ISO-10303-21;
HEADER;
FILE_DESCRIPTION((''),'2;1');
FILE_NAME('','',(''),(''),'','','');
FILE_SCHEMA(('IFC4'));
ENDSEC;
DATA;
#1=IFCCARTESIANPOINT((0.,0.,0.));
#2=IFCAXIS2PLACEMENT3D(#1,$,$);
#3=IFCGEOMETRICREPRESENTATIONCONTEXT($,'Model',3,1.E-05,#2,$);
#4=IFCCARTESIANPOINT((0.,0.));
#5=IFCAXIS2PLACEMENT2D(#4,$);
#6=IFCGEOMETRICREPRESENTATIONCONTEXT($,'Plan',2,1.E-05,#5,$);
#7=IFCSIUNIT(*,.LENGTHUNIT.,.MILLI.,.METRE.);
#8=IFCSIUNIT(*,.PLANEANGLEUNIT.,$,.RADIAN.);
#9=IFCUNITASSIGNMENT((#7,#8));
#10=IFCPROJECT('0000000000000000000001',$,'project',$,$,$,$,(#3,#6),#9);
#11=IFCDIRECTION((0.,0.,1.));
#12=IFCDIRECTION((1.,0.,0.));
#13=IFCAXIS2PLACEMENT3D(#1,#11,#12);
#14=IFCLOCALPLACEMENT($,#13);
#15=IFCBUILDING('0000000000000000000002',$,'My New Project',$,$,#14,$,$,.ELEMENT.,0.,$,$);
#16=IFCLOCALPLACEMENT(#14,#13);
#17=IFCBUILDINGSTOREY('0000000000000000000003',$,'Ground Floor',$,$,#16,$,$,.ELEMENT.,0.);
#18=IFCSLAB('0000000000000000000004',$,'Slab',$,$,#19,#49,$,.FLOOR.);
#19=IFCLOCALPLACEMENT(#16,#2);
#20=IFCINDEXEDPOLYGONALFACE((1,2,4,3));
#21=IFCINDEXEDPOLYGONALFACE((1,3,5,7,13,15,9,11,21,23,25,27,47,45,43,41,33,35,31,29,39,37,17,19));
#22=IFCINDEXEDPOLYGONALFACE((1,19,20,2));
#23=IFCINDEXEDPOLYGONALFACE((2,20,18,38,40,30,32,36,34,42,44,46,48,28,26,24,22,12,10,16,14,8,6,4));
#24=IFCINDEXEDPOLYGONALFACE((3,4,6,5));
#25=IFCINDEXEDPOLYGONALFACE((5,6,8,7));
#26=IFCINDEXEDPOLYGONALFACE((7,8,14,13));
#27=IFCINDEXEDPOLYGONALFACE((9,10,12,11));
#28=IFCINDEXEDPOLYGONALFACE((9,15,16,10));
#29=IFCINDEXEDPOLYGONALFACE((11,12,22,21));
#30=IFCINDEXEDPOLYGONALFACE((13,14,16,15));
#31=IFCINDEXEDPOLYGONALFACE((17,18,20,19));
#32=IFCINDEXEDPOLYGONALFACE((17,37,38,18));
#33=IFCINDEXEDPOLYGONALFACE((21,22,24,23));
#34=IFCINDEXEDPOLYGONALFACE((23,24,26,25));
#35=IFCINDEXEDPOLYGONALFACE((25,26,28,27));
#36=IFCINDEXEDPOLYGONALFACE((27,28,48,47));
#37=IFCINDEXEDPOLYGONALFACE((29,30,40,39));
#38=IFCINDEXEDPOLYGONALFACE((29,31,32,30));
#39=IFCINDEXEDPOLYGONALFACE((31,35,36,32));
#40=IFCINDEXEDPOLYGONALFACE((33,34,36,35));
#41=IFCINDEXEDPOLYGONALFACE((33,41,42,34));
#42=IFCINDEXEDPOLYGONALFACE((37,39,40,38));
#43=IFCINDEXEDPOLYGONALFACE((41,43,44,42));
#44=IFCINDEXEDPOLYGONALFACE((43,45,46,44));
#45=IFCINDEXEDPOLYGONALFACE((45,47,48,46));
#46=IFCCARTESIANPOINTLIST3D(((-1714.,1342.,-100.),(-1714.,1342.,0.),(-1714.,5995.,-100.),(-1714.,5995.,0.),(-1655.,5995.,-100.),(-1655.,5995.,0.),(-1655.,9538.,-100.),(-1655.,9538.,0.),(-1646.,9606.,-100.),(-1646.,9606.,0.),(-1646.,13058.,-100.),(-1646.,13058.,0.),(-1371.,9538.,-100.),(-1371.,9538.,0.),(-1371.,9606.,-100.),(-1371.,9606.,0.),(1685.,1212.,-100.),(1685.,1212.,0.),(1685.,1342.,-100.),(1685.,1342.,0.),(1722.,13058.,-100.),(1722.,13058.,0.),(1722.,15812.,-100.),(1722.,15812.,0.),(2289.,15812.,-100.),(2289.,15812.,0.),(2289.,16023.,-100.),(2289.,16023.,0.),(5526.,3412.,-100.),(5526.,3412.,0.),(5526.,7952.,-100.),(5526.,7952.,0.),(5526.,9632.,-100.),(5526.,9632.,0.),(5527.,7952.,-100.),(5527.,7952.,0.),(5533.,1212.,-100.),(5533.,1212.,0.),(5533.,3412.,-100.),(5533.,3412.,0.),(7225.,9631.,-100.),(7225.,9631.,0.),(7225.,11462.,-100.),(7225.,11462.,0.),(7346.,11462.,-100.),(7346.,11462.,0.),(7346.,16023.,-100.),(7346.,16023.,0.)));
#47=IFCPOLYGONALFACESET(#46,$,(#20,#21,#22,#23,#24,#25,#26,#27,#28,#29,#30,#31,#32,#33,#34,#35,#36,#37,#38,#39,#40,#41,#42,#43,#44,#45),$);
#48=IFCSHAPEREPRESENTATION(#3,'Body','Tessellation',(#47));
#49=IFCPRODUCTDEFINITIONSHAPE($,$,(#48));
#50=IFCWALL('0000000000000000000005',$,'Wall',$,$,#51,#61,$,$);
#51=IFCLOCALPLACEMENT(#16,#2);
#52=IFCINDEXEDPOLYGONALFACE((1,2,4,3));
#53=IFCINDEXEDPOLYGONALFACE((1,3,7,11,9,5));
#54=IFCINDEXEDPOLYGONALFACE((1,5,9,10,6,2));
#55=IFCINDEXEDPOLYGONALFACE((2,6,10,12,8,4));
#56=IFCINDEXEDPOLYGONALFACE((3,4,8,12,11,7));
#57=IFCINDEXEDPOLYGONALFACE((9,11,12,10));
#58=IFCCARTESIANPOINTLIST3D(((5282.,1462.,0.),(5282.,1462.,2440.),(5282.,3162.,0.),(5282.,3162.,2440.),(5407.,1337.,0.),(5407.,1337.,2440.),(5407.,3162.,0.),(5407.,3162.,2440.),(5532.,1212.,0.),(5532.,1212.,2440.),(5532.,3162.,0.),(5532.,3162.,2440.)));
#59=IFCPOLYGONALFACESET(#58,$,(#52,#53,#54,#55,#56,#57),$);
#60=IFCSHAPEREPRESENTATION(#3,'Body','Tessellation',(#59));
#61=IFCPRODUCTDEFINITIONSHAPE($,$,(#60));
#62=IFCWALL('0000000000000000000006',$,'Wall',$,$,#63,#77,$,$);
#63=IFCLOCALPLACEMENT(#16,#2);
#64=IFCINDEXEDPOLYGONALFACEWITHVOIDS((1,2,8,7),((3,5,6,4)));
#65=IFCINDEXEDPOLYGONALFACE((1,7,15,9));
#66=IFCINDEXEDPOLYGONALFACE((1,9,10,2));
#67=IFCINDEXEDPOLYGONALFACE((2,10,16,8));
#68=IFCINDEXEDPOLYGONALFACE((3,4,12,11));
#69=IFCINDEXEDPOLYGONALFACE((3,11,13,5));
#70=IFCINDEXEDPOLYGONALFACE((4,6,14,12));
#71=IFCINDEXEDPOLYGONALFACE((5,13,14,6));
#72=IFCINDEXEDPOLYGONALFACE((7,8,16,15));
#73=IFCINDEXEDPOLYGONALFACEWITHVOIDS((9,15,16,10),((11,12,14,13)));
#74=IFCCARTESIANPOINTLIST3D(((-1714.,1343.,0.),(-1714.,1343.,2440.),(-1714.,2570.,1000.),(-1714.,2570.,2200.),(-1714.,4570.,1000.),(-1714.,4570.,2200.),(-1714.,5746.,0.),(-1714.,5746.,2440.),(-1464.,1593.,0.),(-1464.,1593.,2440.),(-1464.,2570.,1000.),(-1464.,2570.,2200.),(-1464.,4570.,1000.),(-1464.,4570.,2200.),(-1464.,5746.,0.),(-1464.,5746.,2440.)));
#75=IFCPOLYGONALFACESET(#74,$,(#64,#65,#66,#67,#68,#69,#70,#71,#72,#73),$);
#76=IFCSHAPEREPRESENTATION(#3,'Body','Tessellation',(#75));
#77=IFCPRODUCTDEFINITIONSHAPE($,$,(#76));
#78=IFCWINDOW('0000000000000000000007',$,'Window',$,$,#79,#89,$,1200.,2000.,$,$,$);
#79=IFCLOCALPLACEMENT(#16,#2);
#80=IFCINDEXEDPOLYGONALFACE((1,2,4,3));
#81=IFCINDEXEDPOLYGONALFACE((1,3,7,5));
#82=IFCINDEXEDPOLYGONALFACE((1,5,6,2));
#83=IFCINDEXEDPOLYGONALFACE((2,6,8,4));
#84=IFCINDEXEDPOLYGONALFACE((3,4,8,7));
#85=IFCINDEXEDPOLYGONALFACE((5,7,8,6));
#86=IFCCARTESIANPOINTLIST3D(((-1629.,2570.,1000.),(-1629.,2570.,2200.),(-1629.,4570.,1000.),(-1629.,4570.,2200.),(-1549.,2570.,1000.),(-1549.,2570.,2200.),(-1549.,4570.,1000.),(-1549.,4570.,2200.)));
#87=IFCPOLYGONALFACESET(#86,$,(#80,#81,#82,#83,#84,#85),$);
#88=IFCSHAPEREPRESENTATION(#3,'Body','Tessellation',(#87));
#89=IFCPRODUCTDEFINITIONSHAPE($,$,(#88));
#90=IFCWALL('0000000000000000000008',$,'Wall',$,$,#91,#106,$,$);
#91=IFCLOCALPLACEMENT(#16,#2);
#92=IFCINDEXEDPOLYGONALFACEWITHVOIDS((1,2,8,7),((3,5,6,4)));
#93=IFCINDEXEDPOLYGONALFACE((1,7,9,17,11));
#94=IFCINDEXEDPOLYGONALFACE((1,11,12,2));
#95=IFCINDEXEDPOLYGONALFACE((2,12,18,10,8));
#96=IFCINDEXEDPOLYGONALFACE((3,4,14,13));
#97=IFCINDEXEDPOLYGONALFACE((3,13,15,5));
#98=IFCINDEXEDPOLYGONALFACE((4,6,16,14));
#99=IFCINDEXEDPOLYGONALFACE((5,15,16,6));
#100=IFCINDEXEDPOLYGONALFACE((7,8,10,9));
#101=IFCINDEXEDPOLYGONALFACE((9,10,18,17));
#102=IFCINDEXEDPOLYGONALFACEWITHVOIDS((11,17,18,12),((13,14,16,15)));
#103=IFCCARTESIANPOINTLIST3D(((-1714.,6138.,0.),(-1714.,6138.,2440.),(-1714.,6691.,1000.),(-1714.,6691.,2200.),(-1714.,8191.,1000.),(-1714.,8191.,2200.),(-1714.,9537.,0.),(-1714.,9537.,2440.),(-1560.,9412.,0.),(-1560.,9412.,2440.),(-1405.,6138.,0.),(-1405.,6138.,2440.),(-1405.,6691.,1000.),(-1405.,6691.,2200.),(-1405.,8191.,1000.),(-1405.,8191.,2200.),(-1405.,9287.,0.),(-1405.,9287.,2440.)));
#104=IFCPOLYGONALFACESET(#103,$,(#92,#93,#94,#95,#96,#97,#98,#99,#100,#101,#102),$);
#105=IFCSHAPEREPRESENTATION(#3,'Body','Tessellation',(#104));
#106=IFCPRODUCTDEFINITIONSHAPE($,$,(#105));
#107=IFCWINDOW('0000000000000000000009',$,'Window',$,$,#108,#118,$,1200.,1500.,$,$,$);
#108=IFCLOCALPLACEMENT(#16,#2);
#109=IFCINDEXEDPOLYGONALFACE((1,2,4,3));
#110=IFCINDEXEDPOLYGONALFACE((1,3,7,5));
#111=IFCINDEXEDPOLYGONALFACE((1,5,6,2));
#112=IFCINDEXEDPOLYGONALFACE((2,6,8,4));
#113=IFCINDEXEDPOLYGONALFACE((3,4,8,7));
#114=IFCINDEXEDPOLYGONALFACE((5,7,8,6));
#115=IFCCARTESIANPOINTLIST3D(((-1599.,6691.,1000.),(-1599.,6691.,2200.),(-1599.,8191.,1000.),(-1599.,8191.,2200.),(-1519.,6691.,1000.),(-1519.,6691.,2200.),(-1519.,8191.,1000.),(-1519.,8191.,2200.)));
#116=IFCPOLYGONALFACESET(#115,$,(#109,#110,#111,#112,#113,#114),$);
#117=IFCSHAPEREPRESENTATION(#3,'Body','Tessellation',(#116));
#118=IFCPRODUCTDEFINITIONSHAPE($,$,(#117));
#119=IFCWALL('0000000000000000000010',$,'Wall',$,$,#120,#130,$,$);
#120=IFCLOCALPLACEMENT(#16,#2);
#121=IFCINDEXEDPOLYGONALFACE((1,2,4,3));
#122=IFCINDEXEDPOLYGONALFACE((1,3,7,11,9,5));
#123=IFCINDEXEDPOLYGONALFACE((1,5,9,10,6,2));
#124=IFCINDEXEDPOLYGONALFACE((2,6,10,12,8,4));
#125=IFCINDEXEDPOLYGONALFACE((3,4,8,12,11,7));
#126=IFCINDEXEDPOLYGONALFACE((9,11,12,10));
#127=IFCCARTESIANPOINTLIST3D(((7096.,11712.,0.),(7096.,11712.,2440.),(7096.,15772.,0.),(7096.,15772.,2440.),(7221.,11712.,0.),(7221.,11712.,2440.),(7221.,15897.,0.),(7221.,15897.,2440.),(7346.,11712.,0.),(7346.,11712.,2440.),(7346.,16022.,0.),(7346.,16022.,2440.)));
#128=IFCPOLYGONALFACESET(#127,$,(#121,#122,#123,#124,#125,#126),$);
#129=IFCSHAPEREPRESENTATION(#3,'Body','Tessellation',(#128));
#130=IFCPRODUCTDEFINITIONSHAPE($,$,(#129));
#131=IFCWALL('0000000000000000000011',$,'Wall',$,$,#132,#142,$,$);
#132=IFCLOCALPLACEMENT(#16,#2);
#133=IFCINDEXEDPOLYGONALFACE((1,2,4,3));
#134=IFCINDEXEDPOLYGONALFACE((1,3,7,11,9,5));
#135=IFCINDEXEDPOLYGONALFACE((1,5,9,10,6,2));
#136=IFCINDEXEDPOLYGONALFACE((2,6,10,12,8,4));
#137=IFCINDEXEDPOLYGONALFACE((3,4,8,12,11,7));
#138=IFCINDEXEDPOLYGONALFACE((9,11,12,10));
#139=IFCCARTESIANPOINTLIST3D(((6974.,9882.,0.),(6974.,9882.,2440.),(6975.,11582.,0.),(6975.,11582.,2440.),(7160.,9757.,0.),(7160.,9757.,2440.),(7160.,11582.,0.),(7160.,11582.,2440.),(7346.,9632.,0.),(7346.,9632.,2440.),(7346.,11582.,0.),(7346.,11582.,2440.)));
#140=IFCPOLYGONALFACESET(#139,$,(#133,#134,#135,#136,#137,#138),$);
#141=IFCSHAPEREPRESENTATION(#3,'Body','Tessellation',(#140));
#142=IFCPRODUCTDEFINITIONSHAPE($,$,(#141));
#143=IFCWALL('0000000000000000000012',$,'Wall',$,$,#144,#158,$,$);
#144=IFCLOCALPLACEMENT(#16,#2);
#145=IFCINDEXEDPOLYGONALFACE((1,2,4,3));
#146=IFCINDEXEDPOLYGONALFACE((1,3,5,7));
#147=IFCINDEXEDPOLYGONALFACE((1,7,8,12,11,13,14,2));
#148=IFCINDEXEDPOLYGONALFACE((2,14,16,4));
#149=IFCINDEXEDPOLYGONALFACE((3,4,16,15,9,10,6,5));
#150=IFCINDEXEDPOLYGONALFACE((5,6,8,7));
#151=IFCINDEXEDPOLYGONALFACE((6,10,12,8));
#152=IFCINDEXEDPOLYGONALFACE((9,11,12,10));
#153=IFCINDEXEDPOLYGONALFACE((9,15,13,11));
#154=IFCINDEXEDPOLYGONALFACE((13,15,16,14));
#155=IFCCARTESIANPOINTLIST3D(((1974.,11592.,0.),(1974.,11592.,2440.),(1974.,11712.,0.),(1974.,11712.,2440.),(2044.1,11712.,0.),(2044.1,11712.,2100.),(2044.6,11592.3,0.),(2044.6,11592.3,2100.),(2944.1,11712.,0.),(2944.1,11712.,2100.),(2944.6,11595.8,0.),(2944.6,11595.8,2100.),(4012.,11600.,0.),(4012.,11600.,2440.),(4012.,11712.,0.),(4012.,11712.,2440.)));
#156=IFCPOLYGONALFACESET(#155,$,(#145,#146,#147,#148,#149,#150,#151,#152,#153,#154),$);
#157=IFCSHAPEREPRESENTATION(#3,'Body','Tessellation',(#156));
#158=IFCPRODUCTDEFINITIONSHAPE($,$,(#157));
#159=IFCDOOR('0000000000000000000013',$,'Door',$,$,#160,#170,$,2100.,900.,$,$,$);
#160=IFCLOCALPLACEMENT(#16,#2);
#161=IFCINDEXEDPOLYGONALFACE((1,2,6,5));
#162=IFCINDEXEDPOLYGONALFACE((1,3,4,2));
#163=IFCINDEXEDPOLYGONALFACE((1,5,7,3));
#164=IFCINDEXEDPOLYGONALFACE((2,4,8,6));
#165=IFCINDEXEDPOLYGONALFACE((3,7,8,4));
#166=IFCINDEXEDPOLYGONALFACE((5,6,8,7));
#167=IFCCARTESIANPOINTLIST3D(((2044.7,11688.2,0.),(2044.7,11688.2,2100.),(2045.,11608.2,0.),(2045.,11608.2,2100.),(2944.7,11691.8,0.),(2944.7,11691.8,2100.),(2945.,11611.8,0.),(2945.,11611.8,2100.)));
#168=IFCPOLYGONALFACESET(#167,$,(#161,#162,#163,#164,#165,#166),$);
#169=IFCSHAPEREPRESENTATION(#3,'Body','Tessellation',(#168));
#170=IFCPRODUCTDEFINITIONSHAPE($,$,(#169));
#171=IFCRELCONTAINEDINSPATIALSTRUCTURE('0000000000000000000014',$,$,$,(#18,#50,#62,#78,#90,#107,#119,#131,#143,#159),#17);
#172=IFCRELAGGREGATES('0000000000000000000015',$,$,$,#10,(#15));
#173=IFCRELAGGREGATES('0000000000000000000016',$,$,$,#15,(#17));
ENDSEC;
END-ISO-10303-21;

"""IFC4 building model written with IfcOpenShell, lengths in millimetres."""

from ifc_helpers import new_model, si_unit, frame, origin, origin_with_axes, origin_2d, origin_2d_with_axis, place, context, project, spatial, polyline, rectangle, outline, extrude, element, fill, save


model = new_model("IFC4")

# Units and contexts
model_context = context("Model", 3, precision=1e-05, world=origin())
plan_context = context("Plan", 2, precision=1e-05, world=origin_2d())
ifc_project = project(units=[si_unit("LENGTHUNIT", "METRE", prefix="MILLI"), si_unit("PLANEANGLEUNIT", "RADIAN")], contexts=[model_context, plan_context])

# Building, storey
building_placement = place(None, origin_with_axes())
building = spatial("IfcBuilding", under=ifc_project, at=building_placement, Name="My New Project", CompositionType="ELEMENT", ElevationOfRefHeight=0.0)
storey_placement = place(building_placement, origin_with_axes())
storey = spatial("IfcBuildingStorey", under=building, at=storey_placement, Name="Ground Floor", CompositionType="ELEMENT", Elevation=0.0)

# Slab
slab_placement = place(storey_placement, origin_with_axes())
element("IfcSlab", 1, at=slab_placement, inside=storey, Name="Slab", PredefinedType="FLOOR", context=model_context, shape_type="SweptSolid", body=[
    extrude(outline(polyline([(5533.0, 3412.0, 0.0), (5526.0, 3412.0, 0.0), (5526.0, 7952.0, 0.0), (5527.0, 7952.0, 0.0), (5526.0, 9632.0, 0.0), (7225.0, 9631.0, 0.0), (7225.0, 11462.0, 0.0), (7346.0, 11462.0, 0.0), (7346.0, 16023.0, 0.0), (2289.0, 16023.0, 0.0), (2289.0, 15812.0, 0.0), (1722.0, 15812.0, 0.0), (1722.0, 13058.0, 0.0), (-1646.0, 13058.0, 0.0), (-1646.0, 9606.0, 0.0), (-1371.0, 9606.0, 0.0), (-1371.0, 9538.0, 0.0), (-1655.0, 9538.0, 0.0), (-1655.0, 5995.0, 0.0), (-1714.0, 5995.0, 0.0), (-1714.0, 1342.0, 0.0), (1685.0, 1342.0, 0.0), (1685.0, 1212.0, 0.0), (5533.0, 1212.0, 0.0), (5533.0, 3412.0, 0.0)])), origin_with_axes(), (0.0, 0.0, -1.0), 100.0),
])

# Wall
wall_1_placement = place(storey_placement, origin_with_axes())
element("IfcWall", 2, at=wall_1_placement, inside=storey, Name="Wall", context=model_context, shape_type="SweptSolid", body=[
    extrude(outline(polyline([(5407.0, 1337.0, 0.0), (5282.0, 1462.0, 0.0), (5282.0, 3162.0, 0.0), (5407.0, 3162.0, 0.0), (5532.0, 3162.0, 0.0), (5532.0, 1212.0, 0.0), (5407.0, 1337.0, 0.0)])), origin_with_axes(), (0.0, 0.0, 1.0), 2440.0),
])

# Walls, openings, windows
wall_2_placement = place(storey_placement, origin_with_axes())
wall_2 = element("IfcWall", 3, at=wall_2_placement, inside=storey, Name="Wall", context=model_context, shape_type="SweptSolid", body=[
    extrude(outline(polyline([(-1589.0, 5746.0, 0.0), (-1464.0, 5746.0, 0.0), (-1464.0, 1593.0, 0.0), (-1589.0, 1468.0, 0.0), (-1714.0, 1343.0, 0.0), (-1714.0, 5746.0, 0.0), (-1589.0, 5746.0, 0.0)])), origin_with_axes(), (0.0, 0.0, 1.0), 2440.0),
])
opening_1_placement = place(wall_2_placement, frame((-1364.0, 3570.0, 1600.0), z_axis=(0.0, 0.0, 1.0), x_axis=(1.0, 0.0, 0.0)))
opening_1 = element("IfcOpeningElement", 4, at=opening_1_placement, cuts=wall_2, PredefinedType="OPENING", context=model_context, shape_type="SweptSolid", body=[
    extrude(rectangle(XDim=2000.0, YDim=1200.0, at=origin_2d_with_axis()), frame((0.0, 0.0, 0.0), z_axis=(-4153.0, 0.0, 0.0), x_axis=(0.0, -4153.0, 0.0)), (0.0, 0.0, 1.0), 450.0),
])
window_1_placement = place(opening_1_placement, frame((-185.0, 0.0, 0.0), z_axis=(0.0, 0.0, 1.0), x_axis=(1.0, 0.0, 0.0)))
window_1 = element("IfcWindow", 5, at=window_1_placement, inside=storey, Name="Window", OverallHeight=1200.0, OverallWidth=2000.0, context=model_context, shape_type="SweptSolid", body=[
    extrude(outline(polyline([(1000.0, 600.0, 0.0), (1000.0, -600.0, 0.0), (-1000.0, -600.0, 0.0), (-1000.0, 600.0, 0.0), (1000.0, 600.0, 0.0)])), frame((0.0, 0.0, 0.0), z_axis=(-4153.0, 0.0, 0.0), x_axis=(0.0, -4153.0, 0.0)), (0.0, 0.0, 1.0), 80.0),
])
fill(opening_1, window_1)
wall_3_placement = place(storey_placement, origin_with_axes())
wall_3 = element("IfcWall", 6, at=wall_3_placement, inside=storey, Name="Wall", context=model_context, shape_type="SweptSolid", body=[
    extrude(outline(polyline([(-1560.0, 9412.0, 0.0), (-1405.0, 9287.0, 0.0), (-1405.0, 6138.0, 0.0), (-1560.0, 6138.0, 0.0), (-1714.0, 6138.0, 0.0), (-1714.0, 9537.0, 0.0), (-1560.0, 9412.0, 0.0)])), origin_with_axes(), (0.0, 0.0, 1.0), 2440.0),
])
opening_2_placement = place(wall_3_placement, frame((-1305.0, 7441.0, 1600.0), z_axis=(0.0, 0.0, 1.0), x_axis=(1.0, 0.0, 0.0)))
opening_2 = element("IfcOpeningElement", 7, at=opening_2_placement, cuts=wall_3, PredefinedType="OPENING", context=model_context, shape_type="SweptSolid", body=[
    extrude(rectangle(XDim=1500.0, YDim=1200.0, at=origin_2d_with_axis()), frame((0.0, 0.0, 0.0), z_axis=(-3149.0, 0.0, 0.0), x_axis=(0.0, -3149.0, 0.0)), (0.0, 0.0, 1.0), 509.0),
])
window_2_placement = place(opening_2_placement, frame((-214.0, 0.0, 0.0), z_axis=(0.0, 0.0, 1.0), x_axis=(1.0, 0.0, 0.0)))
window_2 = element("IfcWindow", 8, at=window_2_placement, inside=storey, Name="Window", OverallHeight=1200.0, OverallWidth=1500.0, context=model_context, shape_type="SweptSolid", body=[
    extrude(outline(polyline([(750.0, 600.0, 0.0), (750.0, -600.0, 0.0), (-750.0, -600.0, 0.0), (-750.0, 600.0, 0.0), (750.0, 600.0, 0.0)])), frame((0.0, 0.0, 0.0), z_axis=(-3149.0, 0.0, 0.0), x_axis=(0.0, -3149.0, 0.0)), (0.0, 0.0, 1.0), 80.0),
])
fill(opening_2, window_2)

# Walls
wall_4_placement = place(storey_placement, origin_with_axes())
element("IfcWall", 9, at=wall_4_placement, inside=storey, Name="Wall", context=model_context, shape_type="SweptSolid", body=[
    extrude(outline(polyline([(7221.0, 11712.0, 0.0), (7096.0, 11712.0, 0.0), (7096.0, 15772.0, 0.0), (7221.0, 15897.0, 0.0), (7346.0, 16022.0, 0.0), (7346.0, 11712.0, 0.0), (7221.0, 11712.0, 0.0)])), origin_with_axes(), (0.0, 0.0, 1.0), 2440.0),
])
wall_5_placement = place(storey_placement, origin_with_axes())
element("IfcWall", 10, at=wall_5_placement, inside=storey, Name="Wall", context=model_context, shape_type="SweptSolid", body=[
    extrude(outline(polyline([(7160.0, 9757.0, 0.0), (6974.0, 9882.0, 0.0), (6975.0, 11582.0, 0.0), (7160.0, 11582.0, 0.0), (7346.0, 11582.0, 0.0), (7346.0, 9632.0, 0.0), (7160.0, 9757.0, 0.0)])), origin_with_axes(), (0.0, 0.0, 1.0), 2440.0),
])

# Wall, opening, door
wall_6_placement = place(storey_placement, origin_with_axes())
wall_6 = element("IfcWall", 11, at=wall_6_placement, inside=storey, Name="Wall", context=model_context, shape_type="SweptSolid", body=[
    extrude(outline(polyline([(4012.0, 11656.0, 0.0), (4012.0, 11600.0, 0.0), (1974.0, 11592.0, 0.0), (1974.0, 11652.0, 0.0), (1974.0, 11712.0, 0.0), (4012.0, 11712.0, 0.0), (4012.0, 11656.0, 0.0)])), origin_with_axes(), (0.0, 0.0, 1.0), 2440.0),
])
opening_3_placement = place(wall_6_placement, frame((2495.0, 11494.0, 1050.0), z_axis=(0.0, 0.0, 1.0), x_axis=(1.0, 0.0, 0.0)))
opening_3 = element("IfcOpeningElement", 12, at=opening_3_placement, cuts=wall_6, PredefinedType="OPENING", context=model_context, shape_type="SweptSolid", body=[
    extrude(rectangle(XDim=900.0, YDim=2100.0, at=origin_2d_with_axis()), frame((0.0, 0.0, 0.0), z_axis=(-8.0, 2038.0, 0.0), x_axis=(-2038.0, -8.0, 0.0)), (0.0, 0.0, 1.0), 312.0),
])
door_1_placement = place(opening_3_placement, frame((0.0, 116.0, 0.0), z_axis=(0.0, 0.0, 1.0), x_axis=(1.0, 0.0, 0.0)))
door_1 = element("IfcDoor", 13, at=door_1_placement, inside=storey, Name="Door", OverallHeight=2100.0, OverallWidth=900.0, context=model_context, shape_type="SweptSolid", body=[
    extrude(outline(polyline([(450.0, 1050.0, 0.0), (450.0, -1050.0, 0.0), (-450.0, -1050.0, 0.0), (-450.0, 1050.0, 0.0), (450.0, 1050.0, 0.0)])), frame((0.0, 0.0, 0.0), z_axis=(-8.0, 2038.0, 0.0), x_axis=(-2038.0, -8.0, 0.0)), (0.0, 0.0, 1.0), 80.0),
])
fill(opening_3, door_1)

save(model, "model.ifc")
